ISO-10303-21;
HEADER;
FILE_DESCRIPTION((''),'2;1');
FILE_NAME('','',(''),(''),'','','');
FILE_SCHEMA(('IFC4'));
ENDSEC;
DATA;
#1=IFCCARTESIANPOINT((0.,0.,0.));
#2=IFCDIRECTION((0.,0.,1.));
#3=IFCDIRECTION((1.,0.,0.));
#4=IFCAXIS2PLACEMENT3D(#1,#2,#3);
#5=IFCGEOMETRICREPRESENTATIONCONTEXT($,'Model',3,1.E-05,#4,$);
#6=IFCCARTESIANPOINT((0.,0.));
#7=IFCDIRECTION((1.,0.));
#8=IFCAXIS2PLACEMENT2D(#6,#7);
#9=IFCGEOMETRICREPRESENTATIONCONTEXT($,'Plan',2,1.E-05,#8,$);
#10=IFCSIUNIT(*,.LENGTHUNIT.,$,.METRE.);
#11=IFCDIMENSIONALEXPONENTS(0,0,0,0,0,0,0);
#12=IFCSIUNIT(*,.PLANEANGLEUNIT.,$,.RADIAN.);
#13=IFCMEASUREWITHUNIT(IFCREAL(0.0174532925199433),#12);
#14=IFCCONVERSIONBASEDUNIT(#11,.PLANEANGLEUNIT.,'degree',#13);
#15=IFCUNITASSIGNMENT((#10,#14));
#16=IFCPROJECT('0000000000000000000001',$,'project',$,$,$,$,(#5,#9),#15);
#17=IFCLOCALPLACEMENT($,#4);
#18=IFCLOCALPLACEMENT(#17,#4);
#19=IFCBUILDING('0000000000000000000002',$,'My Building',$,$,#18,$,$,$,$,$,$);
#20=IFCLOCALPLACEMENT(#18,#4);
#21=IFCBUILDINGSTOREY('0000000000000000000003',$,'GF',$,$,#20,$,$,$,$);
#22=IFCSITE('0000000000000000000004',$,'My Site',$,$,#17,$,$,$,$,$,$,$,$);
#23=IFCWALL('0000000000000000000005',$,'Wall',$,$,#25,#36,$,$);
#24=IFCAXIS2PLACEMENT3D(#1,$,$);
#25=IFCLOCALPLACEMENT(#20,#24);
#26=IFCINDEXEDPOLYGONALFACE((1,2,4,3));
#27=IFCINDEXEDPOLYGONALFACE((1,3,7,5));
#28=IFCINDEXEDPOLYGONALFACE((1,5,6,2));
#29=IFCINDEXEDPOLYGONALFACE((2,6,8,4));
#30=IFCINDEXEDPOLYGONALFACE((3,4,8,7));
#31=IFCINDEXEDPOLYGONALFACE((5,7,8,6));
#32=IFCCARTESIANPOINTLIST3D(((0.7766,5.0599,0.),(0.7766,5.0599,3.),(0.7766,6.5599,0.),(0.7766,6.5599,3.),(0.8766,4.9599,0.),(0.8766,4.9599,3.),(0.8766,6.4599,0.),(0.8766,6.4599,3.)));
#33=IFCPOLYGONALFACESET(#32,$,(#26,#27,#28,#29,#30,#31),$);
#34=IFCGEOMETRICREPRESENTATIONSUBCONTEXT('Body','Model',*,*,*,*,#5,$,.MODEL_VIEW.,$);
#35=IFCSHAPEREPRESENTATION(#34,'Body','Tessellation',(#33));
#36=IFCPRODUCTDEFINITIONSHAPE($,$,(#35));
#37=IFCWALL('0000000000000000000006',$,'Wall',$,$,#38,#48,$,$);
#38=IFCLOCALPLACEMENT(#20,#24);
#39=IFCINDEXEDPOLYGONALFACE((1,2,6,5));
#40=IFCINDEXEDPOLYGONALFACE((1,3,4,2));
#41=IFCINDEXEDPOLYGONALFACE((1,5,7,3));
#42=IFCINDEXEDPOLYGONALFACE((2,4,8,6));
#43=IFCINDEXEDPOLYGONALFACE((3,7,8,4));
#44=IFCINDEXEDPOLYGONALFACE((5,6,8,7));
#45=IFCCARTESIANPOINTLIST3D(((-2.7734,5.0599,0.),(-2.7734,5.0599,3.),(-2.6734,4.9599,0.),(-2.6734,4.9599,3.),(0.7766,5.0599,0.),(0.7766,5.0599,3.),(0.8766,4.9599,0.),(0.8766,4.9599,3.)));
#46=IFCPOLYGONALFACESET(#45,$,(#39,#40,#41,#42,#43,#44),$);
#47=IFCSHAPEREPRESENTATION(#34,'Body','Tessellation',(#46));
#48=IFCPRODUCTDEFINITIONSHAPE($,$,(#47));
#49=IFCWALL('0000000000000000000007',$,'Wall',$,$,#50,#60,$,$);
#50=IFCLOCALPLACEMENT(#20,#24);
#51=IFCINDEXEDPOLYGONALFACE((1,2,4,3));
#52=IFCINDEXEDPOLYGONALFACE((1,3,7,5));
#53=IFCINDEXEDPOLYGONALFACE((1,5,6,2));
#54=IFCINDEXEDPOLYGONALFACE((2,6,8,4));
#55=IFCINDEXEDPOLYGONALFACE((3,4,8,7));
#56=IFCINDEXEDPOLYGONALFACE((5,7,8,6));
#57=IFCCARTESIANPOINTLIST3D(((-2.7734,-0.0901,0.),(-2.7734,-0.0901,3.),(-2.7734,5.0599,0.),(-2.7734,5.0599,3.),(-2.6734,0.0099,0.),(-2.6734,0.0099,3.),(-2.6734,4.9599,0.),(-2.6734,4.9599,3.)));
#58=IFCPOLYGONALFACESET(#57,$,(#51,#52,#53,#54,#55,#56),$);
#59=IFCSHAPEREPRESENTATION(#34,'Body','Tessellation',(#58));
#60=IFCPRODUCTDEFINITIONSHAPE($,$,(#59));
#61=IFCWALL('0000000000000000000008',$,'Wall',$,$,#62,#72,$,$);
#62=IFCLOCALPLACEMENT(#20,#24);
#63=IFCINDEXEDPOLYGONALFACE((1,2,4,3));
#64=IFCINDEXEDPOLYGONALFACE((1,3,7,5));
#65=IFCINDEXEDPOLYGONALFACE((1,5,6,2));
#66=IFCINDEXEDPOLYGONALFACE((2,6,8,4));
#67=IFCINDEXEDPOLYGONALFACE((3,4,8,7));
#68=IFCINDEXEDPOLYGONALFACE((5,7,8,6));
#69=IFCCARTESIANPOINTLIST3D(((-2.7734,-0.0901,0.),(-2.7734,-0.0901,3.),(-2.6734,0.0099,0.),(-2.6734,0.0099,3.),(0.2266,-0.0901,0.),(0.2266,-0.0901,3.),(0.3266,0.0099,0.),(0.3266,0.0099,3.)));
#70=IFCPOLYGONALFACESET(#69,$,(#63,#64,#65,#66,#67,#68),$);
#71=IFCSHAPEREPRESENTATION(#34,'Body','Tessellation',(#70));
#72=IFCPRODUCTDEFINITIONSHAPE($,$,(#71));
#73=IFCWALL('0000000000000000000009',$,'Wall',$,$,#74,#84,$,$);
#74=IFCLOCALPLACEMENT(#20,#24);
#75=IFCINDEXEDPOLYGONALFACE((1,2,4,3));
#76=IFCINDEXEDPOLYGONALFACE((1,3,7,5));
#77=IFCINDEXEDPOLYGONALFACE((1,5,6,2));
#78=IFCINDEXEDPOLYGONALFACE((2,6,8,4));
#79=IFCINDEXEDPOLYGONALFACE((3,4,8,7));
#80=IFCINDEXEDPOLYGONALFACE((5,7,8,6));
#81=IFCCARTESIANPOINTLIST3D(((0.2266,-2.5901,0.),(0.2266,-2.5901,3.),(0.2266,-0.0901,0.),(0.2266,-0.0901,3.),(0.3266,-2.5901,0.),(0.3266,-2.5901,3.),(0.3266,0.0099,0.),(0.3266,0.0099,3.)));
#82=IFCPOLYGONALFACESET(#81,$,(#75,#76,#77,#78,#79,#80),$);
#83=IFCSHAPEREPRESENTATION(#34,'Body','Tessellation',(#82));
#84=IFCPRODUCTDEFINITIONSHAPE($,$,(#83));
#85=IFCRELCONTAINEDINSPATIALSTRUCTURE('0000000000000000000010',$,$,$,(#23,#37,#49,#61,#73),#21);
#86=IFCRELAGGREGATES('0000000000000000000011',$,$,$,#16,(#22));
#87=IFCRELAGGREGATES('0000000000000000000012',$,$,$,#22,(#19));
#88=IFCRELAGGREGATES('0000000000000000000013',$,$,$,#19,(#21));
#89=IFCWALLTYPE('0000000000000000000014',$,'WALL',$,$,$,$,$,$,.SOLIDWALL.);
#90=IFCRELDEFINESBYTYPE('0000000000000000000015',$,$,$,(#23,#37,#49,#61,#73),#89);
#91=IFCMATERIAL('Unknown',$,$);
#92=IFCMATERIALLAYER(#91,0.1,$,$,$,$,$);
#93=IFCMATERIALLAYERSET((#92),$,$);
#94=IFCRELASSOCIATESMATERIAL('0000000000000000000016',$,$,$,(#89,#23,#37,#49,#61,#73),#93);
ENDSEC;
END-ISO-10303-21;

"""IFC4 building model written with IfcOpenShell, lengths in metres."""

from ifc_helpers import new_model, entity, si_unit, converted_unit, frame, origin_with_axes, origin_2d_with_axis, place, context, subcontext, project, spatial, line, indexed_curve, outline, extrude, material, layer, layer_set, layer_usage, type_object, element, save


model = new_model("IFC4")

# Units and contexts
model_context = context("Model", 3, precision=1e-05, world=origin_with_axes())
plan_context = context("Plan", 2, precision=1e-05, world=origin_2d_with_axis())
body_context_1 = subcontext(model_context, "Body", "Model", "MODEL_VIEW")
ifc_project = project(units=[si_unit("LENGTHUNIT", "METRE"), converted_unit("PLANEANGLEUNIT", "degree", entity("IfcReal", 0.0174532925199433), si_unit("PLANEANGLEUNIT", "RADIAN"), dimensions=[0, 0, 0, 0, 0, 0, 0])], contexts=[model_context, plan_context])

# Site, building, storey
site_placement = place(None, origin_with_axes())
site = spatial("IfcSite", under=ifc_project, at=site_placement, Name="My Site")
building_placement = place(site_placement, origin_with_axes())
building = spatial("IfcBuilding", under=site, at=building_placement, Name="My Building")
storey_placement = place(building_placement, origin_with_axes())
storey = spatial("IfcBuildingStorey", under=building, at=storey_placement, Name="GF")

# Shared definitions
ifc_material = material(Name="Unknown")

# Shared definitions
ifc_layer_1 = layer(ifc_material, 0.1)
ifc_layer_set_1 = layer_set([ifc_layer_1])
wall_type = type_object("IfcWallType", Name="WALL", PredefinedType="SOLIDWALL", material=ifc_layer_set_1)

# Walls
ifc_layer_usage_1 = layer_usage(ifc_layer_set_1, "AXIS2", "POSITIVE", 0.0)
wall_1_placement = place(storey_placement, frame((0.7766, 6.5599, 0.0), z_axis=(0.0, 0.0, 1.0), x_axis=(0.0, -1.0, 0.0)))
element("IfcWall", 1, at=wall_1_placement, inside=storey, type_object=wall_type, material=ifc_layer_usage_1, Name="Wall", context=body_context_1, shape_type="SweptSolid", body=[
    extrude(outline(indexed_curve([(0.0, 0.0), (0.1, 0.1), (1.6, 0.1), (1.5, 0.0)], segments=[line(1, 2, 3, 4, 1)])), origin_with_axes(), (0.0, 0.0, 1.0), 3.0),
])
ifc_layer_usage_2 = layer_usage(ifc_layer_set_1, "AXIS2", "POSITIVE", 0.0)
wall_2_placement = place(storey_placement, frame((0.7766, 5.0599, 0.0), z_axis=(0.0, 0.0, 1.0), x_axis=(-1.0, 0.0, 0.0)))
element("IfcWall", 2, at=wall_2_placement, inside=storey, type_object=wall_type, material=ifc_layer_usage_2, Name="Wall", context=body_context_1, shape_type="SweptSolid", body=[
    extrude(outline(indexed_curve([(0.0, 0.0), (-0.1, 0.1), (3.45, 0.1), (3.55, 0.0)], segments=[line(1, 2, 3, 4, 1)])), origin_with_axes(), (0.0, 0.0, 1.0), 3.0),
])
ifc_layer_usage_3 = layer_usage(ifc_layer_set_1, "AXIS2", "POSITIVE", 0.0)
wall_3_placement = place(storey_placement, frame((-2.7734, 5.0599, 0.0), z_axis=(0.0, 0.0, 1.0), x_axis=(0.0, -1.0, 0.0)))
element("IfcWall", 3, at=wall_3_placement, inside=storey, type_object=wall_type, material=ifc_layer_usage_3, Name="Wall", context=body_context_1, shape_type="SweptSolid", body=[
    extrude(outline(indexed_curve([(0.0, 0.0), (0.1, 0.1), (5.05, 0.1), (5.15, 0.0)], segments=[line(1, 2, 3, 4, 1)])), origin_with_axes(), (0.0, 0.0, 1.0), 3.0),
])
ifc_layer_usage_4 = layer_usage(ifc_layer_set_1, "AXIS2", "POSITIVE", 0.0)
wall_4_placement = place(storey_placement, frame((-2.7734, -0.0901, 0.0), z_axis=(0.0, 0.0, 1.0), x_axis=(1.0, 0.0, 0.0)))
element("IfcWall", 4, at=wall_4_placement, inside=storey, type_object=wall_type, material=ifc_layer_usage_4, Name="Wall", context=body_context_1, shape_type="SweptSolid", body=[
    extrude(outline(indexed_curve([(0.0, 0.0), (0.1, 0.1), (3.1, 0.1), (3.0, 0.0)], segments=[line(1, 2, 3, 4, 1)])), origin_with_axes(), (0.0, 0.0, 1.0), 3.0),
])
ifc_layer_usage_5 = layer_usage(ifc_layer_set_1, "AXIS2", "POSITIVE", 0.0)
wall_5_placement = place(storey_placement, frame((0.2266, -0.0901, 0.0), z_axis=(0.0, 0.0, 1.0), x_axis=(0.0, -1.0, 0.0)))
element("IfcWall", 5, at=wall_5_placement, inside=storey, type_object=wall_type, material=ifc_layer_usage_5, Name="Wall", context=body_context_1, shape_type="SweptSolid", body=[
    extrude(outline(indexed_curve([(0.0, 0.0), (-0.1, 0.1), (2.5, 0.1), (2.5, 0.0)], segments=[line(1, 2, 3, 4, 1)])), origin_with_axes(), (0.0, 0.0, 1.0), 3.0),
])

save(model, "model.ifc")
